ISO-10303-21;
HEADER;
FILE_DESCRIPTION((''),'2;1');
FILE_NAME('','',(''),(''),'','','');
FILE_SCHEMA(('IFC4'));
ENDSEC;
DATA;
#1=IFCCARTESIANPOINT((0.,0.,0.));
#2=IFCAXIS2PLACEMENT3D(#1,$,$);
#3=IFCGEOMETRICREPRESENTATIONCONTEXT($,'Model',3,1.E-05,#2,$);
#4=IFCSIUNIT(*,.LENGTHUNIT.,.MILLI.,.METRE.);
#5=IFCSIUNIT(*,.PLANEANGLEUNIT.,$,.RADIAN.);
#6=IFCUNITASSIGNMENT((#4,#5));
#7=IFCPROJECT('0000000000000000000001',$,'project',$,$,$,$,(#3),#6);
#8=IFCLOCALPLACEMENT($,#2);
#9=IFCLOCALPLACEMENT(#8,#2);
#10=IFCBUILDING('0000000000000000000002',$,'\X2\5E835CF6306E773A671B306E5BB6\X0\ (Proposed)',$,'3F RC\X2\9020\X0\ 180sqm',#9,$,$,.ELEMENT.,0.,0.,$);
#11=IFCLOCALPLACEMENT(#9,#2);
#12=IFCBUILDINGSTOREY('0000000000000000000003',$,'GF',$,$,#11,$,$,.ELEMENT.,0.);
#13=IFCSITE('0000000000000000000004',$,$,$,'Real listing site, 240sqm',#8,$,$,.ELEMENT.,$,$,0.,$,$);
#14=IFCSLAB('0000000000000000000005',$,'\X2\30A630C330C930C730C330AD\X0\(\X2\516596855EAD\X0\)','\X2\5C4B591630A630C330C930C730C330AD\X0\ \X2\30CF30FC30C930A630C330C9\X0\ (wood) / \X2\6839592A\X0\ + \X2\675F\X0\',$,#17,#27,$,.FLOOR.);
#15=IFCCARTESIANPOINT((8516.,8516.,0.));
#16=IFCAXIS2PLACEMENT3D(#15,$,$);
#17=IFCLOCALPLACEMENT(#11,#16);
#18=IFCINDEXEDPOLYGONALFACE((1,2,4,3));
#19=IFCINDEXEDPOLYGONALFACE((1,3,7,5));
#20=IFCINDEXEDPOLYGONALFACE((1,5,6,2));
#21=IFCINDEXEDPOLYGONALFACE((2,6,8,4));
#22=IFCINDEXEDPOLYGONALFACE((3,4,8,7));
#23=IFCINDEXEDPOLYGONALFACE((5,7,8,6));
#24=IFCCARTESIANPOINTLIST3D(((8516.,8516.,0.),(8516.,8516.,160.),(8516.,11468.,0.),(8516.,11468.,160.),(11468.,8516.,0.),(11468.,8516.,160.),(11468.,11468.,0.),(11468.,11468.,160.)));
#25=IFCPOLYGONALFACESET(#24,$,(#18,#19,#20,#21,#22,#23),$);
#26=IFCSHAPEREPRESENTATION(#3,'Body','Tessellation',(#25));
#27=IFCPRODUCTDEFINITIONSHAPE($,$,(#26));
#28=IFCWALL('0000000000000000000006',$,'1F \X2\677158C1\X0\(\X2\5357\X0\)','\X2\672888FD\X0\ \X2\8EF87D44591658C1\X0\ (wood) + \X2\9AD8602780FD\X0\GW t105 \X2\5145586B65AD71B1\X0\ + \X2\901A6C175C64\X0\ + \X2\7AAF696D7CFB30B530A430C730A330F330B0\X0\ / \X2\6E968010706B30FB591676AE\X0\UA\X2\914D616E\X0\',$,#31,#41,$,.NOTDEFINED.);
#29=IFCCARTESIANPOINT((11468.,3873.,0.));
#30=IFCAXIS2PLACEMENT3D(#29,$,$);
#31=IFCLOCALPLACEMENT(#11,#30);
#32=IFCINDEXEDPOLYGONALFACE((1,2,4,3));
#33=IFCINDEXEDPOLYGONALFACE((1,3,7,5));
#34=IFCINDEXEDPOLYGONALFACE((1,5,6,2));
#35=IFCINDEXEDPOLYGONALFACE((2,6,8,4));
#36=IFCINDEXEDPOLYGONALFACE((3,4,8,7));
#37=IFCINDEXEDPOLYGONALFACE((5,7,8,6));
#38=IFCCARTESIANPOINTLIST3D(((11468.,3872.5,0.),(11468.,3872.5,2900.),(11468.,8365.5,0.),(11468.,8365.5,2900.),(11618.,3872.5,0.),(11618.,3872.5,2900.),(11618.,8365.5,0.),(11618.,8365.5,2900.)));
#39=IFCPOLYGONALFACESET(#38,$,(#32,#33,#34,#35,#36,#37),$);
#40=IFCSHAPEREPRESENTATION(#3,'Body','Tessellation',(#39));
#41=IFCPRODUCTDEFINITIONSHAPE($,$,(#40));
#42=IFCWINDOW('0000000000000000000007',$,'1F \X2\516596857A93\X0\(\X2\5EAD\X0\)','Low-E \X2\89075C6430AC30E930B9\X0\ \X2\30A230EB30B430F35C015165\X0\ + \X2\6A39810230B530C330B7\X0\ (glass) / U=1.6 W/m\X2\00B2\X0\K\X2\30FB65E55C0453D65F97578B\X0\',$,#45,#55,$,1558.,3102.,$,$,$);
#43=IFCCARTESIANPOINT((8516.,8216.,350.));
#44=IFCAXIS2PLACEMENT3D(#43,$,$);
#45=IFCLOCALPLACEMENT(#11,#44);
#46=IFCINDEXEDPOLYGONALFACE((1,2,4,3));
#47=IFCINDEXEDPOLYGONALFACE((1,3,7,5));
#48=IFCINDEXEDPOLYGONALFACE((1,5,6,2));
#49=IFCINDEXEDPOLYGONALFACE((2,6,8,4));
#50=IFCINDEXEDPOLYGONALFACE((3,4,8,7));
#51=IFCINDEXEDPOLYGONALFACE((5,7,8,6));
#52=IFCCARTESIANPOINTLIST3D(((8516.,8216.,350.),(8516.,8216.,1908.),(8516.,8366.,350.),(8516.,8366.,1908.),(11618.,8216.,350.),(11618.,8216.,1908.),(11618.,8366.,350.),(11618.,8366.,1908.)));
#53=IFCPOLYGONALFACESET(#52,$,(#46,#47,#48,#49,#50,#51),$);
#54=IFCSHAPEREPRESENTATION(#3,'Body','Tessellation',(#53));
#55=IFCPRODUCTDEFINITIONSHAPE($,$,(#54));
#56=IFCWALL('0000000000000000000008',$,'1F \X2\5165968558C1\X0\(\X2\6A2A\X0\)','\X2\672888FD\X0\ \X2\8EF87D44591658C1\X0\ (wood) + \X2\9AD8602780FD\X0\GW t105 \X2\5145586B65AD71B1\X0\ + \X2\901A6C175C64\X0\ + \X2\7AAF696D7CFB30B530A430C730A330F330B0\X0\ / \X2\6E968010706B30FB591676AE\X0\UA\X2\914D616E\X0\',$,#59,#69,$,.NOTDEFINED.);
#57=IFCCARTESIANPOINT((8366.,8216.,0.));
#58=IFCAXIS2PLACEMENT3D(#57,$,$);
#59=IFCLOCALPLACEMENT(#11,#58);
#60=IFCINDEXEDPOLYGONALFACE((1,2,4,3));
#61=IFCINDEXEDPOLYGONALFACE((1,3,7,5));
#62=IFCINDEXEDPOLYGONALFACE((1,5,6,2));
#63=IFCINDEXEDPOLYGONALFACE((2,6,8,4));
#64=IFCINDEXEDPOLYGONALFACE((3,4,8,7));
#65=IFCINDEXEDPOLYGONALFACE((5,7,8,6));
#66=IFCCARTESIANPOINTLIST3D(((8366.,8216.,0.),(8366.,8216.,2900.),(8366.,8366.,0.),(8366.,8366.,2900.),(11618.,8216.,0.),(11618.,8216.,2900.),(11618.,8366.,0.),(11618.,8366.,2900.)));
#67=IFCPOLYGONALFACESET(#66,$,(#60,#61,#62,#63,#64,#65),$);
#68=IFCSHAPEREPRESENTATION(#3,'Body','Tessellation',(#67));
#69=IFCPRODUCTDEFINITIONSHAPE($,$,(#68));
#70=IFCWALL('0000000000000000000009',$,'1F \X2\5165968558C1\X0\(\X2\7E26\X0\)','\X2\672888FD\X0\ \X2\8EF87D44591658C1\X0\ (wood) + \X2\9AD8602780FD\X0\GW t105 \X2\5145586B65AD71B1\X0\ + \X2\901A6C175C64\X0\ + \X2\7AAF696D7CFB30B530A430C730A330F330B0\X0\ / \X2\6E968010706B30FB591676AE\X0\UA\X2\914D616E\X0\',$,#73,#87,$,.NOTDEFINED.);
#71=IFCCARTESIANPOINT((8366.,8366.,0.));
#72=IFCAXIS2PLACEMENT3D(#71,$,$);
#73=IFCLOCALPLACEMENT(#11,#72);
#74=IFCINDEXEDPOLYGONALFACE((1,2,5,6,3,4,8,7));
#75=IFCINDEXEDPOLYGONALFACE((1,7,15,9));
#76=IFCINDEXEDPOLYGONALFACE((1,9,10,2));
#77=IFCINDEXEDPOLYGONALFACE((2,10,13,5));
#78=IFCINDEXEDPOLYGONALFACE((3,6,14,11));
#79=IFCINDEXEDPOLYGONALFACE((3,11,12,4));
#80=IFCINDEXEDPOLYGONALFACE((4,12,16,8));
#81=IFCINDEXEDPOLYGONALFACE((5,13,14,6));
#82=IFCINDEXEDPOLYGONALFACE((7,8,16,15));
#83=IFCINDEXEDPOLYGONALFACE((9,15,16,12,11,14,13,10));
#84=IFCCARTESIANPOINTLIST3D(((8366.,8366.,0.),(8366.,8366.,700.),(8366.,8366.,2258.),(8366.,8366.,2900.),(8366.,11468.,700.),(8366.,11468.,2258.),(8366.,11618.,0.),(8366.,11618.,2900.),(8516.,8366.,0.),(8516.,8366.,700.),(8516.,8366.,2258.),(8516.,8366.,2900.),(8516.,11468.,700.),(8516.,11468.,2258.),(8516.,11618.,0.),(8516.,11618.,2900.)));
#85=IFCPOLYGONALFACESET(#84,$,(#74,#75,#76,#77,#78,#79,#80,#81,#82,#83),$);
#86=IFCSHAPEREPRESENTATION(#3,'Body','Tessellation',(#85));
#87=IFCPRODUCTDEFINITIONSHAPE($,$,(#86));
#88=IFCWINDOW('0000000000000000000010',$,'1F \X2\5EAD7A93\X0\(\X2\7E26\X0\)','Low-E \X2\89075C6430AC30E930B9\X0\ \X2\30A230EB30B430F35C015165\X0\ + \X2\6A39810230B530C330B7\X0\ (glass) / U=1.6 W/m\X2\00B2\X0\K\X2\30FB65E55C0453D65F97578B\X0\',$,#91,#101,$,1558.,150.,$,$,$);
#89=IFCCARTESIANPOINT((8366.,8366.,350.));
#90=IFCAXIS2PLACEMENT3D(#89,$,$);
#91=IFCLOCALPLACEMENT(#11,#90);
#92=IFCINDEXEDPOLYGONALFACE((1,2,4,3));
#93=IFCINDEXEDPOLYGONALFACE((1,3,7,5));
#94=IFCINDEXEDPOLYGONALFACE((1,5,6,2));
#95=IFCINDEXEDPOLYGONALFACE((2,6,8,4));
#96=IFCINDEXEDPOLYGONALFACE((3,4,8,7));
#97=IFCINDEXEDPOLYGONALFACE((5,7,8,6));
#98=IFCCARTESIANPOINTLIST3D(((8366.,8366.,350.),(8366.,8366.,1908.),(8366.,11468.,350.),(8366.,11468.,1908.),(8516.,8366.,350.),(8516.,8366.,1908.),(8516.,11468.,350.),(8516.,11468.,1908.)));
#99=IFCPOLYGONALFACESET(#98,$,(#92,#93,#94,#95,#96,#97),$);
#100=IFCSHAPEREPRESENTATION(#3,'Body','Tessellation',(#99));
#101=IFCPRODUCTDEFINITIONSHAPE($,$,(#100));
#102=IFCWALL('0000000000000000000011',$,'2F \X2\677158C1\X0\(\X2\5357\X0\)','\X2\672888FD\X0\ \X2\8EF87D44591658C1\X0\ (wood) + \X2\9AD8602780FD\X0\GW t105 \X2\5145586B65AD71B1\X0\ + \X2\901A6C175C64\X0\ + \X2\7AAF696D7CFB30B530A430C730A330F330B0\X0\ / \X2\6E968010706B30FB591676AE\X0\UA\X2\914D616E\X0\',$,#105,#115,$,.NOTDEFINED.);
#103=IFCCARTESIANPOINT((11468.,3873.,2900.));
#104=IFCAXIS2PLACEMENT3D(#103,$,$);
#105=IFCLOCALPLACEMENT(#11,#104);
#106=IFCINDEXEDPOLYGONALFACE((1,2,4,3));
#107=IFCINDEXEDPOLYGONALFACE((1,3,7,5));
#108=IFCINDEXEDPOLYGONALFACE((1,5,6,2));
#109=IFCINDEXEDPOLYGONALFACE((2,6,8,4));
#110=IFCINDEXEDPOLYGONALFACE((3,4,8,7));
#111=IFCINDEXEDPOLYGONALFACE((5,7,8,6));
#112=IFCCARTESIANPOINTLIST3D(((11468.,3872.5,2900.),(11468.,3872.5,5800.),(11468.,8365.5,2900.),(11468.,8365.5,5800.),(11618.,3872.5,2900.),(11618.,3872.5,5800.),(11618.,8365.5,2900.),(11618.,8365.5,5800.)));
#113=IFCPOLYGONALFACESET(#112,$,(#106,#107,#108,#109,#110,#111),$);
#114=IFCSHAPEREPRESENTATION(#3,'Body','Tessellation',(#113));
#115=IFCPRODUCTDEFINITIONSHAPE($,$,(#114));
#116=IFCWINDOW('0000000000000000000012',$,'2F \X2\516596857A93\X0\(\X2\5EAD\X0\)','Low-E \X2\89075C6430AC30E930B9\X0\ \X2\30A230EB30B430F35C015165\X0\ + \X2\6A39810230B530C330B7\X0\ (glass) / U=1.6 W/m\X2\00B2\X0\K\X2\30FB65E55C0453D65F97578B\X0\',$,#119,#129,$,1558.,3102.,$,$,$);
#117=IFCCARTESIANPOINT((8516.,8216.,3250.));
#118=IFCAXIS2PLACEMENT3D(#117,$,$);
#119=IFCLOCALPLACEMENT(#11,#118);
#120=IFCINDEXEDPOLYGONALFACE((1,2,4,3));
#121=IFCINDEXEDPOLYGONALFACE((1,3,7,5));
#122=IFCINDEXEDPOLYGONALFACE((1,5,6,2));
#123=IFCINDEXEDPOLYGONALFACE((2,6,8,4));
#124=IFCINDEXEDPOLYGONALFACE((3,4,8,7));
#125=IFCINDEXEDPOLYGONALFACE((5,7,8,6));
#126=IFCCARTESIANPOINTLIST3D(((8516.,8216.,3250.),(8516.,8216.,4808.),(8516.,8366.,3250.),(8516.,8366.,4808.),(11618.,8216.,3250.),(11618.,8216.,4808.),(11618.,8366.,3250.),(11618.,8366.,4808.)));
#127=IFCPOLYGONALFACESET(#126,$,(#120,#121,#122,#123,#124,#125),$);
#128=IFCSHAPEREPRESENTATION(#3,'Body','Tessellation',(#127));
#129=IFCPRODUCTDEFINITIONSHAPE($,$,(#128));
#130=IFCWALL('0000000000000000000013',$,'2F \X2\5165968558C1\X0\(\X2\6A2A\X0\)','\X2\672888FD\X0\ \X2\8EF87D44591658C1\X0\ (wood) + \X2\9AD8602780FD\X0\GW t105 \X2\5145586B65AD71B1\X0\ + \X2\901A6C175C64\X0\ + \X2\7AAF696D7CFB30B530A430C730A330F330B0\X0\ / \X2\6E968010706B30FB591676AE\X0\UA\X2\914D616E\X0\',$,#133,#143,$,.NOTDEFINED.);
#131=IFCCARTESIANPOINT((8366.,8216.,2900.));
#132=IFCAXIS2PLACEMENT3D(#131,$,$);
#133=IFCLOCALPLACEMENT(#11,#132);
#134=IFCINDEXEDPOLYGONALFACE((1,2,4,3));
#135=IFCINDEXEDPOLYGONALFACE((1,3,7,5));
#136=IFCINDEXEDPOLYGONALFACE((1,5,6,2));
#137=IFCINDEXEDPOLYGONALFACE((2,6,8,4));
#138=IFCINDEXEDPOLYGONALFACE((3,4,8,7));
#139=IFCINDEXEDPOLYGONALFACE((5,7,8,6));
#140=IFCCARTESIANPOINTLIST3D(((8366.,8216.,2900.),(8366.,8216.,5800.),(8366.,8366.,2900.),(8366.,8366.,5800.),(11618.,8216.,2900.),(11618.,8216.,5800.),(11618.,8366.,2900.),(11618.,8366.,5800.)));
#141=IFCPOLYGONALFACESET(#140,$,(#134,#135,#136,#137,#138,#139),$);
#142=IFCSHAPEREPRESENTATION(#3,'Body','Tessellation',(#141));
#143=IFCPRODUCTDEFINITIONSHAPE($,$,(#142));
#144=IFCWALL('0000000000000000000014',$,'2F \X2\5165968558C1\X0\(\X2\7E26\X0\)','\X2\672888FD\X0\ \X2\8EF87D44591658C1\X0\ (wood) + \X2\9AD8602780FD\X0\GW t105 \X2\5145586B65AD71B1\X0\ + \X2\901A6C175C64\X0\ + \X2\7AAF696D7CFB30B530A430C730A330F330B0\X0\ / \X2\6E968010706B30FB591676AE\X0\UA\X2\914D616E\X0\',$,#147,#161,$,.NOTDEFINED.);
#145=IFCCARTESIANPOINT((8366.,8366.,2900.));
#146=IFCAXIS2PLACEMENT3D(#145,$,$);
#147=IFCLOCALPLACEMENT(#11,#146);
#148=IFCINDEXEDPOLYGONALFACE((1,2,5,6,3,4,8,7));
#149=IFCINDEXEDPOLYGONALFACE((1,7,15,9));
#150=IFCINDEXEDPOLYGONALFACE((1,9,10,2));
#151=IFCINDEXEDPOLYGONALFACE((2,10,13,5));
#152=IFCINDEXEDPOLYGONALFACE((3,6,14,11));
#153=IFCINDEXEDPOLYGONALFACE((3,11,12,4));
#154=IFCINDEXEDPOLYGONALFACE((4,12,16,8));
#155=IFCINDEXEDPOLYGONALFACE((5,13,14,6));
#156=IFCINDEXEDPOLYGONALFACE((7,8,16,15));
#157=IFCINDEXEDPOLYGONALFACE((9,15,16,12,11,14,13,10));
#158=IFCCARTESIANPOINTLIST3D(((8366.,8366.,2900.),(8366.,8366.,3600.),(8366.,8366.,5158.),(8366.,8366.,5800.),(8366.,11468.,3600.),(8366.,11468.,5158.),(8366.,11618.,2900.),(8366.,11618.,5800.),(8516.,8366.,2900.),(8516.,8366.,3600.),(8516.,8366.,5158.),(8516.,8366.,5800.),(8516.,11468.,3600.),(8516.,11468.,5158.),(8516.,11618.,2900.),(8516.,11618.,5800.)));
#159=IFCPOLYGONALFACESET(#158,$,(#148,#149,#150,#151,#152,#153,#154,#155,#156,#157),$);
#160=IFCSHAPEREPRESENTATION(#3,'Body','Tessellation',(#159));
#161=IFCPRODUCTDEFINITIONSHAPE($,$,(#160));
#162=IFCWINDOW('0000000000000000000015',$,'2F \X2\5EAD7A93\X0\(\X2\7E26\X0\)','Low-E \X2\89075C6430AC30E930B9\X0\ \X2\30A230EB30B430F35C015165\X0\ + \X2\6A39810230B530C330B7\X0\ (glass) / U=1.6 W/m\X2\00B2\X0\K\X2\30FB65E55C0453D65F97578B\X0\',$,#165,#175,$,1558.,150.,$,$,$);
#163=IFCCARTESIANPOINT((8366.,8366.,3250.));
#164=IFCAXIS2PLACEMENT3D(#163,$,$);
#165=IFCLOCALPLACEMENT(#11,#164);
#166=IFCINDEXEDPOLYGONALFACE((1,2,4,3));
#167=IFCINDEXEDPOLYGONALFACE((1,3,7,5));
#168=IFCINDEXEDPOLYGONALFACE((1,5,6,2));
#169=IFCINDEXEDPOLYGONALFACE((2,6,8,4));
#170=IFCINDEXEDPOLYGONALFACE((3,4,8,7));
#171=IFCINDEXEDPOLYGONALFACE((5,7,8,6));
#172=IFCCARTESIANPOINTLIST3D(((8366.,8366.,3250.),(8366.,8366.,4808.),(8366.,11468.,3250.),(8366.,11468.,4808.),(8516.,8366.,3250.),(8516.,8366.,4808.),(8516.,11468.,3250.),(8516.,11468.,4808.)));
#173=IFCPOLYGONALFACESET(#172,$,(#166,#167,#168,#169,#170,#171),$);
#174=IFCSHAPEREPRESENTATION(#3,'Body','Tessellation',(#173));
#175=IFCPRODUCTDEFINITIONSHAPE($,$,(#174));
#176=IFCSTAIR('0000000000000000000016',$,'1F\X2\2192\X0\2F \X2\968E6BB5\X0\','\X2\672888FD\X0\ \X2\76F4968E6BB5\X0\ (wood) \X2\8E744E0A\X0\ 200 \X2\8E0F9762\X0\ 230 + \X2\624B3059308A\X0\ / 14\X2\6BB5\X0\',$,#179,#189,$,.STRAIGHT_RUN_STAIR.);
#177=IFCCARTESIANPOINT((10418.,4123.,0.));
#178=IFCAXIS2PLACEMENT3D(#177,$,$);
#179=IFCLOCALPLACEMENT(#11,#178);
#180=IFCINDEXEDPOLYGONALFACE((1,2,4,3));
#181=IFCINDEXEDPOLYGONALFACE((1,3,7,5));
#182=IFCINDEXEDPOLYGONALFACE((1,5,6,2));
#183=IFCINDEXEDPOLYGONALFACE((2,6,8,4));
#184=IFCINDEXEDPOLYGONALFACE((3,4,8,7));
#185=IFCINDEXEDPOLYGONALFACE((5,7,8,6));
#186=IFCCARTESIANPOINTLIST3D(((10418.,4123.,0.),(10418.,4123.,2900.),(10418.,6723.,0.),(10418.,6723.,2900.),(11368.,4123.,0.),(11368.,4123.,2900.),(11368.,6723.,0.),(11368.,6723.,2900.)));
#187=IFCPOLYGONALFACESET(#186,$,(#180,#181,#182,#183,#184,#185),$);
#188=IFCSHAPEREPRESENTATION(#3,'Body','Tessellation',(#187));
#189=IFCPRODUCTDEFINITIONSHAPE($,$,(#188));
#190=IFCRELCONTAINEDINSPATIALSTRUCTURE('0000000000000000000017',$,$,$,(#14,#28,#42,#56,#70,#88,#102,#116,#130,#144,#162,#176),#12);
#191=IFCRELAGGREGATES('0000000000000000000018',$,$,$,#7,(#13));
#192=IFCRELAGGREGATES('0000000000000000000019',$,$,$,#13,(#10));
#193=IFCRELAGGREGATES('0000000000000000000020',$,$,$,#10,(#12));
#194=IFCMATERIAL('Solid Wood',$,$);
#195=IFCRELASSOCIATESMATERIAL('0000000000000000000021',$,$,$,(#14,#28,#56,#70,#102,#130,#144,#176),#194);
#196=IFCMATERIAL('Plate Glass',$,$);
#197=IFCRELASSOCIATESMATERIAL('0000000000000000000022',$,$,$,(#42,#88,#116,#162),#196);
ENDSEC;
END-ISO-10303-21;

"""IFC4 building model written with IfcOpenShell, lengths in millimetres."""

from ifc_helpers import new_model, si_unit, frame, frame_2d, origin, place, context, project, spatial, rectangle, extrude, material, element, fill, save


model = new_model("IFC4")

# Units and contexts
model_context = context("Model", 3, precision=1e-05, world=origin())
ifc_project = project(units=[si_unit("LENGTHUNIT", "METRE", prefix="MILLI"), si_unit("PLANEANGLEUNIT", "RADIAN")], contexts=[model_context])

# Site, building, storey
site_placement = place(None, origin())
site = spatial("IfcSite", under=ifc_project, at=site_placement, ObjectType="Real listing site, 240sqm", CompositionType="ELEMENT", RefElevation=0.0)
building_placement = place(site_placement, origin())
building = spatial("IfcBuilding", under=site, at=building_placement, Name="広島の眺望の家 (Proposed)", ObjectType="3F RC造 180sqm", CompositionType="ELEMENT", ElevationOfRefHeight=0.0, ElevationOfTerrain=0.0)
storey_placement = place(building_placement, origin())
storey = spatial("IfcBuildingStorey", under=building, at=storey_placement, Name="GF", CompositionType="ELEMENT", Elevation=0.0)

# Slab
ifc_material_1 = material(Name="Solid Wood")
slab_placement = place(storey_placement, frame((8516.0, 8516.0, 0.0)))
element("IfcSlab", 1, at=slab_placement, inside=storey, material=ifc_material_1, Name="ウッドデッキ(入隅庭)", Description="屋外ウッドデッキ ハードウッド (wood) / 根太 + 束", PredefinedType="FLOOR", context=model_context, shape_type="SweptSolid", body=[
    extrude(rectangle(XDim=2952.0, YDim=2952.0, at=frame_2d((1476.0, 1476.0))), frame((8516.0, 8516.0, 0.0)), (0.0, 0.0, 1.0), 160.0),
])

# Wall, opening, window
wall_1_placement = place(storey_placement, frame((11468.0, 3873.0, 0.0)))
wall_1 = element("IfcWall", 2, at=wall_1_placement, inside=storey, material=ifc_material_1, Name="1F 東壁(南)", Description="木製 軸組外壁 (wood) + 高性能GW t105 充填断熱 + 通気層 + 窯業系サイディング / 準耐火・外皮UA配慮", PredefinedType="NOTDEFINED", context=model_context, shape_type="SweptSolid", body=[
    extrude(rectangle(XDim=150.0, YDim=4493.0, at=frame_2d((75.0, 2246.0))), frame((11468.0, 3873.0, 0.0)), (0.0, 0.0, 1.0), 2900.0),
])
opening_1_placement = place(storey_placement, frame((8516.0, 8216.0, 350.0)))
opening_1 = element("IfcOpeningElement", 3, at=opening_1_placement, cuts=wall_1, PredefinedType="NOTDEFINED", context=model_context, shape_type="SweptSolid", body=[
    extrude(rectangle(XDim=3102.0, YDim=150.0, at=frame_2d((1551.0, 75.0))), frame((8516.0, 8216.0, 350.0)), (0.0, 0.0, 1.0), 1558.0),
])
ifc_material_2 = material(Name="Plate Glass")
window_1_placement = place(storey_placement, frame((8516.0, 8216.0, 350.0)))
window_1 = element("IfcWindow", 4, at=window_1_placement, inside=storey, material=ifc_material_2, Name="1F 入隅窓(庭)", Description="Low-E 複層ガラス アルゴン封入 + 樹脂サッシ (glass) / U=1.6 W/m²K・日射取得型", OverallHeight=1558.0, OverallWidth=3102.0, context=model_context, shape_type="SweptSolid", body=[
    extrude(rectangle(XDim=3102.0, YDim=150.0, at=frame_2d((1551.0, 75.0))), frame((8516.0, 8216.0, 350.0)), (0.0, 0.0, 1.0), 1558.0),
])
fill(opening_1, window_1)

# Wall
wall_2_placement = place(storey_placement, frame((8366.0, 8216.0, 0.0)))
element("IfcWall", 5, at=wall_2_placement, inside=storey, material=ifc_material_1, Name="1F 入隅壁(横)", Description="木製 軸組外壁 (wood) + 高性能GW t105 充填断熱 + 通気層 + 窯業系サイディング / 準耐火・外皮UA配慮", PredefinedType="NOTDEFINED", context=model_context, shape_type="SweptSolid", body=[
    extrude(rectangle(XDim=3252.0, YDim=150.0, at=frame_2d((1626.0, 75.0))), frame((8366.0, 8216.0, 0.0)), (0.0, 0.0, 1.0), 2900.0),
])

# Wall, opening, window
wall_3_placement = place(storey_placement, frame((8366.0, 8366.0, 0.0)))
wall_3 = element("IfcWall", 6, at=wall_3_placement, inside=storey, material=ifc_material_1, Name="1F 入隅壁(縦)", Description="木製 軸組外壁 (wood) + 高性能GW t105 充填断熱 + 通気層 + 窯業系サイディング / 準耐火・外皮UA配慮", PredefinedType="NOTDEFINED", context=model_context, shape_type="SweptSolid", body=[
    extrude(rectangle(XDim=150.0, YDim=3252.0, at=frame_2d((75.0, 1626.0))), frame((8366.0, 8366.0, 0.0)), (0.0, 0.0, 1.0), 2900.0),
])
opening_2_placement = place(storey_placement, frame((8366.0, 8366.0, 350.0)))
opening_2 = element("IfcOpeningElement", 7, at=opening_2_placement, cuts=wall_3, PredefinedType="NOTDEFINED", context=model_context, shape_type="SweptSolid", body=[
    extrude(rectangle(XDim=150.0, YDim=3102.0, at=frame_2d((75.0, 1551.0))), frame((8366.0, 8366.0, 350.0)), (0.0, 0.0, 1.0), 1558.0),
])
window_2_placement = place(storey_placement, frame((8366.0, 8366.0, 350.0)))
window_2 = element("IfcWindow", 8, at=window_2_placement, inside=storey, material=ifc_material_2, Name="1F 庭窓(縦)", Description="Low-E 複層ガラス アルゴン封入 + 樹脂サッシ (glass) / U=1.6 W/m²K・日射取得型", OverallHeight=1558.0, OverallWidth=150.0, context=model_context, shape_type="SweptSolid", body=[
    extrude(rectangle(XDim=150.0, YDim=3102.0, at=frame_2d((75.0, 1551.0))), frame((8366.0, 8366.0, 350.0)), (0.0, 0.0, 1.0), 1558.0),
])
fill(opening_2, window_2)

# Wall, opening, window
wall_4_placement = place(storey_placement, frame((11468.0, 3873.0, 2900.0)))
wall_4 = element("IfcWall", 9, at=wall_4_placement, inside=storey, material=ifc_material_1, Name="2F 東壁(南)", Description="木製 軸組外壁 (wood) + 高性能GW t105 充填断熱 + 通気層 + 窯業系サイディング / 準耐火・外皮UA配慮", PredefinedType="NOTDEFINED", context=model_context, shape_type="SweptSolid", body=[
    extrude(rectangle(XDim=150.0, YDim=4493.0, at=frame_2d((75.0, 2246.0))), frame((11468.0, 3873.0, 2900.0)), (0.0, 0.0, 1.0), 2900.0),
])
opening_3_placement = place(storey_placement, frame((8516.0, 8216.0, 3250.0)))
opening_3 = element("IfcOpeningElement", 10, at=opening_3_placement, cuts=wall_4, PredefinedType="NOTDEFINED", context=model_context, shape_type="SweptSolid", body=[
    extrude(rectangle(XDim=3102.0, YDim=150.0, at=frame_2d((1551.0, 75.0))), frame((8516.0, 8216.0, 3250.0)), (0.0, 0.0, 1.0), 1558.0),
])
window_3_placement = place(storey_placement, frame((8516.0, 8216.0, 3250.0)))
window_3 = element("IfcWindow", 11, at=window_3_placement, inside=storey, material=ifc_material_2, Name="2F 入隅窓(庭)", Description="Low-E 複層ガラス アルゴン封入 + 樹脂サッシ (glass) / U=1.6 W/m²K・日射取得型", OverallHeight=1558.0, OverallWidth=3102.0, context=model_context, shape_type="SweptSolid", body=[
    extrude(rectangle(XDim=3102.0, YDim=150.0, at=frame_2d((1551.0, 75.0))), frame((8516.0, 8216.0, 3250.0)), (0.0, 0.0, 1.0), 1558.0),
])
fill(opening_3, window_3)

# Wall
wall_5_placement = place(storey_placement, frame((8366.0, 8216.0, 2900.0)))
element("IfcWall", 12, at=wall_5_placement, inside=storey, material=ifc_material_1, Name="2F 入隅壁(横)", Description="木製 軸組外壁 (wood) + 高性能GW t105 充填断熱 + 通気層 + 窯業系サイディング / 準耐火・外皮UA配慮", PredefinedType="NOTDEFINED", context=model_context, shape_type="SweptSolid", body=[
    extrude(rectangle(XDim=3252.0, YDim=150.0, at=frame_2d((1626.0, 75.0))), frame((8366.0, 8216.0, 2900.0)), (0.0, 0.0, 1.0), 2900.0),
])

# Wall, opening, window
wall_6_placement = place(storey_placement, frame((8366.0, 8366.0, 2900.0)))
wall_6 = element("IfcWall", 13, at=wall_6_placement, inside=storey, material=ifc_material_1, Name="2F 入隅壁(縦)", Description="木製 軸組外壁 (wood) + 高性能GW t105 充填断熱 + 通気層 + 窯業系サイディング / 準耐火・外皮UA配慮", PredefinedType="NOTDEFINED", context=model_context, shape_type="SweptSolid", body=[
    extrude(rectangle(XDim=150.0, YDim=3252.0, at=frame_2d((75.0, 1626.0))), frame((8366.0, 8366.0, 2900.0)), (0.0, 0.0, 1.0), 2900.0),
])
opening_4_placement = place(storey_placement, frame((8366.0, 8366.0, 3250.0)))
opening_4 = element("IfcOpeningElement", 14, at=opening_4_placement, cuts=wall_6, PredefinedType="NOTDEFINED", context=model_context, shape_type="SweptSolid", body=[
    extrude(rectangle(XDim=150.0, YDim=3102.0, at=frame_2d((75.0, 1551.0))), frame((8366.0, 8366.0, 3250.0)), (0.0, 0.0, 1.0), 1558.0),
])
window_4_placement = place(storey_placement, frame((8366.0, 8366.0, 3250.0)))
window_4 = element("IfcWindow", 15, at=window_4_placement, inside=storey, material=ifc_material_2, Name="2F 庭窓(縦)", Description="Low-E 複層ガラス アルゴン封入 + 樹脂サッシ (glass) / U=1.6 W/m²K・日射取得型", OverallHeight=1558.0, OverallWidth=150.0, context=model_context, shape_type="SweptSolid", body=[
    extrude(rectangle(XDim=150.0, YDim=3102.0, at=frame_2d((75.0, 1551.0))), frame((8366.0, 8366.0, 3250.0)), (0.0, 0.0, 1.0), 1558.0),
])
fill(opening_4, window_4)

# Stair
stair_placement = place(storey_placement, frame((10418.0, 4123.0, 0.0)))
element("IfcStair", 16, at=stair_placement, inside=storey, material=ifc_material_1, Name="1F→2F 階段", Description="木製 直階段 (wood) 蹴上 200 踏面 230 + 手すり / 14段", PredefinedType="STRAIGHT_RUN_STAIR", context=model_context, shape_type="SweptSolid", body=[
    extrude(rectangle(XDim=950.0, YDim=2600.0, at=frame_2d((475.0, 1300.0))), frame((10418.0, 4123.0, 0.0)), (0.0, 0.0, 1.0), 2900.0),
])

save(model, "model.ifc")
